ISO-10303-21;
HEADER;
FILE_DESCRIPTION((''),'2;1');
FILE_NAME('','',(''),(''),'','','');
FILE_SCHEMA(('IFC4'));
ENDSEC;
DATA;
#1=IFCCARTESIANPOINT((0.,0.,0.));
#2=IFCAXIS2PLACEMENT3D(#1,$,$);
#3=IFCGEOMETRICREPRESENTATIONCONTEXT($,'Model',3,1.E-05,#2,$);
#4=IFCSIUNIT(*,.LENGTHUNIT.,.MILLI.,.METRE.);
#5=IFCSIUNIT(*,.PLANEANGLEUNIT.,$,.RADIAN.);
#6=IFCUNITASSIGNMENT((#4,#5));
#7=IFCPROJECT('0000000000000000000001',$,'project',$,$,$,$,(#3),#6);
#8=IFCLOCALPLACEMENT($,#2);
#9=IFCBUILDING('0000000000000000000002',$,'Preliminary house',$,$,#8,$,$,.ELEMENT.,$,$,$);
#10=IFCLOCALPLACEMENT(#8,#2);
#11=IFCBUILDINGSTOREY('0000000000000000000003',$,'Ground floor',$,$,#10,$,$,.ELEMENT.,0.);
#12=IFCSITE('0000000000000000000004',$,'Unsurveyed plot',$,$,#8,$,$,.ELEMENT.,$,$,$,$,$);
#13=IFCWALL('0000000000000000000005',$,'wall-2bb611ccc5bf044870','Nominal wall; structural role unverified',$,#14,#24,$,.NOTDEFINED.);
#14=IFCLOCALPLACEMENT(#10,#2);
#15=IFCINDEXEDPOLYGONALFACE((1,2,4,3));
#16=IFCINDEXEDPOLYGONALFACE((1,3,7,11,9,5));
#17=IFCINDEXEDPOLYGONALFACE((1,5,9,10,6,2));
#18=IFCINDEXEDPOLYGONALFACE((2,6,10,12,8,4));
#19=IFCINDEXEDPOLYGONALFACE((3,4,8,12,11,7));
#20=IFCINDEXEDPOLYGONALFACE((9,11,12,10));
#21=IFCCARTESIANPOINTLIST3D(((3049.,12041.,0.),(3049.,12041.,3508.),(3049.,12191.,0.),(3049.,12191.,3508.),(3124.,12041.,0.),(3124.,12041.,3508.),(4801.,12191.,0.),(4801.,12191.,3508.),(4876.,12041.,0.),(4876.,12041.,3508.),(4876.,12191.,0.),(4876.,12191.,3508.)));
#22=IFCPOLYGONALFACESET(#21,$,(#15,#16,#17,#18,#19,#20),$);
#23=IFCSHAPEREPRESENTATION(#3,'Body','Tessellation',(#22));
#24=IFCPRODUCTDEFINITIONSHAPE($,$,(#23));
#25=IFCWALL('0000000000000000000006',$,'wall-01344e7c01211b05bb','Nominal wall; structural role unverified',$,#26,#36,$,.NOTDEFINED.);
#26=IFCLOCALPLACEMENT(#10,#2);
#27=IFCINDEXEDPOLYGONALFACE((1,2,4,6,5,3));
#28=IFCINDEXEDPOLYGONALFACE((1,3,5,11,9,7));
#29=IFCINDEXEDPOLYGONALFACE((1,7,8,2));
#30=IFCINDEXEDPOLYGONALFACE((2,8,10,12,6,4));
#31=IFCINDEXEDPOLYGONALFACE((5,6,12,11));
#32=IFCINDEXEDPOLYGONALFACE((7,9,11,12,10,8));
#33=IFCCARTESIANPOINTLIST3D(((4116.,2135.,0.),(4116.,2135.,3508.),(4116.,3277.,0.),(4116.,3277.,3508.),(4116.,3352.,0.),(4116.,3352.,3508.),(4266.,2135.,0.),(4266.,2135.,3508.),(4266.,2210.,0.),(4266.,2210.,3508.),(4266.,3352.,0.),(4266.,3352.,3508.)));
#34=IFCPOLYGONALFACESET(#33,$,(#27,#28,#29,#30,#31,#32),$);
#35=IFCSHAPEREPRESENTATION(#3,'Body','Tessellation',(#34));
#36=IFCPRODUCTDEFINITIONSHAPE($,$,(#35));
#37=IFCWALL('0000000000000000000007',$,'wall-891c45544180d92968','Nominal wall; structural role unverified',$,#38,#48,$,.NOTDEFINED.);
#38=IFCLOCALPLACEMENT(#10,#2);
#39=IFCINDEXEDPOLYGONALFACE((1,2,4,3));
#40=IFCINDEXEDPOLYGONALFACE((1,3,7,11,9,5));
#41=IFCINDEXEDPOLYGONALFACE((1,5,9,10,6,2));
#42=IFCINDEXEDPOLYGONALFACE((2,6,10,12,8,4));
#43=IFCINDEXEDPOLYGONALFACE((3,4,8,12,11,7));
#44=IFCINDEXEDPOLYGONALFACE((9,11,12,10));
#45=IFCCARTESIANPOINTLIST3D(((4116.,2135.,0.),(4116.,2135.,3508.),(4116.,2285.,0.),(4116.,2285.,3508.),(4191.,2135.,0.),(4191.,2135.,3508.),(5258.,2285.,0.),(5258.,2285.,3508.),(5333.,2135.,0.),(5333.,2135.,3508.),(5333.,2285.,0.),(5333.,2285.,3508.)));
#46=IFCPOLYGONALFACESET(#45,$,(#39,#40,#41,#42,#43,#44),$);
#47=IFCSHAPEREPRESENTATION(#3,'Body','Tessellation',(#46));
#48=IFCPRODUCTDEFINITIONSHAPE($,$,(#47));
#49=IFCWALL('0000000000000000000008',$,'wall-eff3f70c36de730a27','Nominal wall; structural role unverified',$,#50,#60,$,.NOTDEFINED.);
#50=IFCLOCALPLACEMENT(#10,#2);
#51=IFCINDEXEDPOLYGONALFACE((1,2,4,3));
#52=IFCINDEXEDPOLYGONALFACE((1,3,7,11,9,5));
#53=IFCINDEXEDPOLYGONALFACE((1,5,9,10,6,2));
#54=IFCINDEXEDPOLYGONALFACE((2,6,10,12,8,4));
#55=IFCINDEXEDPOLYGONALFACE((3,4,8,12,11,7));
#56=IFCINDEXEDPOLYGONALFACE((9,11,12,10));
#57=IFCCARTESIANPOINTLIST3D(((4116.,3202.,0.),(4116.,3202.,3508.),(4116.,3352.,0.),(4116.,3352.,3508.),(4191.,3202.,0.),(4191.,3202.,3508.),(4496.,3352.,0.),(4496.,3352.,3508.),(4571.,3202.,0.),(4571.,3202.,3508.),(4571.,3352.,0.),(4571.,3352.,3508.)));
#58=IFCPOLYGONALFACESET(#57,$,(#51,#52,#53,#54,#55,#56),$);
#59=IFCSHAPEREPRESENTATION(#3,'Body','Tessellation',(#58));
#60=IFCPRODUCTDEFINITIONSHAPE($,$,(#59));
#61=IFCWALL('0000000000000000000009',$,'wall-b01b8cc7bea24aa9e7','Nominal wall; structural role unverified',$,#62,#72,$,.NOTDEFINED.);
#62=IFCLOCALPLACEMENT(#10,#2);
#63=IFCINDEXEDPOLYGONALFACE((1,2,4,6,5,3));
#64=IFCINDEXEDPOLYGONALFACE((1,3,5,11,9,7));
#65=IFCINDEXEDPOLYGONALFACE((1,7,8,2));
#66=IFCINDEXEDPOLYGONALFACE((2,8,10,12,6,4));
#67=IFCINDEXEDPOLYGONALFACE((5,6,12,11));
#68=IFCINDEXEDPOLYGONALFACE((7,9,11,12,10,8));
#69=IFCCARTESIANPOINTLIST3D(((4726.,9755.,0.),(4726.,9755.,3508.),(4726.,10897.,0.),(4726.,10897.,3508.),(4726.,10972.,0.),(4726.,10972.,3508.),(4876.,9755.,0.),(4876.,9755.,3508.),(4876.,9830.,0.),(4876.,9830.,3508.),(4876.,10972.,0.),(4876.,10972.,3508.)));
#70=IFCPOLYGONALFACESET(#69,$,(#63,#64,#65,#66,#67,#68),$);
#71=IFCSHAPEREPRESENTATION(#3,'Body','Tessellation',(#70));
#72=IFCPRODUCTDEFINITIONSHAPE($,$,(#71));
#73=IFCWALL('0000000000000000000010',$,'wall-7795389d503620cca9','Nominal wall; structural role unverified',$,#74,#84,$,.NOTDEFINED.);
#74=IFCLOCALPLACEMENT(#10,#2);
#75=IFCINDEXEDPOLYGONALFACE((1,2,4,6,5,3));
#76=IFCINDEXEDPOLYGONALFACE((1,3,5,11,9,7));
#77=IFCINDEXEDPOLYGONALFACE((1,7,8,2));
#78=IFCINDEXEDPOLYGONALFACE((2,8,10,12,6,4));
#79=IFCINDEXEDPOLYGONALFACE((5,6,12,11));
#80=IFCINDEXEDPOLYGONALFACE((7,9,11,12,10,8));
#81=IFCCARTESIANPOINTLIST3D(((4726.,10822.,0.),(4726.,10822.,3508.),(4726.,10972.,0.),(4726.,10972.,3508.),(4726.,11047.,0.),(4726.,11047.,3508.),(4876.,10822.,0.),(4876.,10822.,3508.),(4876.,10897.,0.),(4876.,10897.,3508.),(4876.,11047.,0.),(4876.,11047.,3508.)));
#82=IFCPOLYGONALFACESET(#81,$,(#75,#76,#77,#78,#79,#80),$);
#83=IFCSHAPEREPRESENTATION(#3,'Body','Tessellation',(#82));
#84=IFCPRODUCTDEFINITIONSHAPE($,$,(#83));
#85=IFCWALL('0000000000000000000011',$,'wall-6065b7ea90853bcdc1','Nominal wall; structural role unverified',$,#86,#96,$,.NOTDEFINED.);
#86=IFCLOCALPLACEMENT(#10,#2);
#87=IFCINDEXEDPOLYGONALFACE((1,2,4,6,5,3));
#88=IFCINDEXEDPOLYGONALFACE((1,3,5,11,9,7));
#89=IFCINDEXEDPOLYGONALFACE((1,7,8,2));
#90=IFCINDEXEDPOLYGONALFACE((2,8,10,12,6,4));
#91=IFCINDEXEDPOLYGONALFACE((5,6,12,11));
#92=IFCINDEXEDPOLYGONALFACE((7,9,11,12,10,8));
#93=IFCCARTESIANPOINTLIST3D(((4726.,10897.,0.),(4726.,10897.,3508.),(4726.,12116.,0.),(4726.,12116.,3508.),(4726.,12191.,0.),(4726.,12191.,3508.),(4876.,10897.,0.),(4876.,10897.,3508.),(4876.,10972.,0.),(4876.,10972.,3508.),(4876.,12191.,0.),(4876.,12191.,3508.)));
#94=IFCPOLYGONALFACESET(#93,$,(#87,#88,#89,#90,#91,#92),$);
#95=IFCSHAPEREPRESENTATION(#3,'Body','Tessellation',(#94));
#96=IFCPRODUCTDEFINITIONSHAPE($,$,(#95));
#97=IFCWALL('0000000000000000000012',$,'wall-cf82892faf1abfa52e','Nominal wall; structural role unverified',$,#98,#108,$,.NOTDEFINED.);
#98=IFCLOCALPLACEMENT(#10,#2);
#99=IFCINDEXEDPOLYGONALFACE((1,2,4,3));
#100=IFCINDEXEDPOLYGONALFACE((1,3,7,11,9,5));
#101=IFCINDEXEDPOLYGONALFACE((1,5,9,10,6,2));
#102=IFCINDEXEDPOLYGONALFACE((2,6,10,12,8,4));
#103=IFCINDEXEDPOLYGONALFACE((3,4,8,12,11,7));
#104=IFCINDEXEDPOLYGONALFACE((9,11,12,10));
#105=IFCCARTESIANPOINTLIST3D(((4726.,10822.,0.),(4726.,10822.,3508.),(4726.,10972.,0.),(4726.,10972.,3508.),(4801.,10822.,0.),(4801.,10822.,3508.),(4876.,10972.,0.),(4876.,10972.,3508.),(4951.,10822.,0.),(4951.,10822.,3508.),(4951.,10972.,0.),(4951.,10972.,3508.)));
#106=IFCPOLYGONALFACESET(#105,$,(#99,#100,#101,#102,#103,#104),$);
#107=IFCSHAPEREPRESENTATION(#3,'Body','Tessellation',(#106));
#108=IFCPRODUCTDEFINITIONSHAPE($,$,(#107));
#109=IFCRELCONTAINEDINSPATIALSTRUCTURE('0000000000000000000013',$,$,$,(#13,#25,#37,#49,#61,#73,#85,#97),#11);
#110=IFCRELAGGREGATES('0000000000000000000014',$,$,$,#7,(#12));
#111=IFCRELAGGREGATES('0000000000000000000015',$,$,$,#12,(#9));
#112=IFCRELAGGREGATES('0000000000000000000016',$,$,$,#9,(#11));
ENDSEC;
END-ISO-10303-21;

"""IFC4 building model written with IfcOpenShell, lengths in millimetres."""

from ifc_helpers import new_model, si_unit, origin, place, context, project, spatial, polyline, outline, extrude, element, save


model = new_model("IFC4")

# Units and contexts
model_context = context("Model", 3, precision=1e-05, world=origin())
ifc_project = project(units=[si_unit("LENGTHUNIT", "METRE", prefix="MILLI"), si_unit("PLANEANGLEUNIT", "RADIAN")], contexts=[model_context])

# Site, building, storey
placement_1 = place(None, origin())
site = spatial("IfcSite", under=ifc_project, at=placement_1, Name="Unsurveyed plot", CompositionType="ELEMENT")
building = spatial("IfcBuilding", under=site, at=placement_1, Name="Preliminary house", CompositionType="ELEMENT")
placement_2 = place(placement_1, origin())
storey = spatial("IfcBuildingStorey", under=building, at=placement_2, Name="Ground floor", CompositionType="ELEMENT", Elevation=0.0)

# Wall
element("IfcWall", 1, at=placement_2, inside=storey, Name="wall-2bb611ccc5bf044870", Description="Nominal wall; structural role unverified", PredefinedType="NOTDEFINED", context=model_context, shape_type="SweptSolid", body=[
    extrude(outline(polyline([(4801.0, 12191.0), (4876.0, 12191.0), (4876.0, 12041.0), (3124.0, 12041.0), (3049.0, 12041.0), (3049.0, 12191.0), (4801.0, 12191.0)])), origin(), (0.0, 0.0, 1.0), 3508.0),
])

# Walls
element("IfcWall", 2, at=placement_2, inside=storey, Name="wall-01344e7c01211b05bb", Description="Nominal wall; structural role unverified", PredefinedType="NOTDEFINED", context=model_context, shape_type="SweptSolid", body=[
    extrude(outline(polyline([(4116.0, 3277.0), (4116.0, 3352.0), (4266.0, 3352.0), (4266.0, 2210.0), (4266.0, 2135.0), (4116.0, 2135.0), (4116.0, 3277.0)])), origin(), (0.0, 0.0, 1.0), 3508.0),
])
element("IfcWall", 3, at=placement_2, inside=storey, Name="wall-891c45544180d92968", Description="Nominal wall; structural role unverified", PredefinedType="NOTDEFINED", context=model_context, shape_type="SweptSolid", body=[
    extrude(outline(polyline([(5258.0, 2285.0), (5333.0, 2285.0), (5333.0, 2135.0), (4191.0, 2135.0), (4116.0, 2135.0), (4116.0, 2285.0), (5258.0, 2285.0)])), origin(), (0.0, 0.0, 1.0), 3508.0),
])
element("IfcWall", 4, at=placement_2, inside=storey, Name="wall-eff3f70c36de730a27", Description="Nominal wall; structural role unverified", PredefinedType="NOTDEFINED", context=model_context, shape_type="SweptSolid", body=[
    extrude(outline(polyline([(4496.0, 3352.0), (4571.0, 3352.0), (4571.0, 3202.0), (4191.0, 3202.0), (4116.0, 3202.0), (4116.0, 3352.0), (4496.0, 3352.0)])), origin(), (0.0, 0.0, 1.0), 3508.0),
])

# Wall
element("IfcWall", 5, at=placement_2, inside=storey, Name="wall-b01b8cc7bea24aa9e7", Description="Nominal wall; structural role unverified", PredefinedType="NOTDEFINED", context=model_context, shape_type="SweptSolid", body=[
    extrude(outline(polyline([(4726.0, 10897.0), (4726.0, 10972.0), (4876.0, 10972.0), (4876.0, 9830.0), (4876.0, 9755.0), (4726.0, 9755.0), (4726.0, 10897.0)])), origin(), (0.0, 0.0, 1.0), 3508.0),
])

# Walls
element("IfcWall", 6, at=placement_2, inside=storey, Name="wall-7795389d503620cca9", Description="Nominal wall; structural role unverified", PredefinedType="NOTDEFINED", context=model_context, shape_type="SweptSolid", body=[
    extrude(outline(polyline([(4726.0, 10972.0), (4726.0, 11047.0), (4876.0, 11047.0), (4876.0, 10897.0), (4876.0, 10822.0), (4726.0, 10822.0), (4726.0, 10972.0)])), origin(), (0.0, 0.0, 1.0), 3508.0),
])
element("IfcWall", 7, at=placement_2, inside=storey, Name="wall-6065b7ea90853bcdc1", Description="Nominal wall; structural role unverified", PredefinedType="NOTDEFINED", context=model_context, shape_type="SweptSolid", body=[
    extrude(outline(polyline([(4726.0, 12116.0), (4726.0, 12191.0), (4876.0, 12191.0), (4876.0, 10972.0), (4876.0, 10897.0), (4726.0, 10897.0), (4726.0, 12116.0)])), origin(), (0.0, 0.0, 1.0), 3508.0),
])
element("IfcWall", 8, at=placement_2, inside=storey, Name="wall-cf82892faf1abfa52e", Description="Nominal wall; structural role unverified", PredefinedType="NOTDEFINED", context=model_context, shape_type="SweptSolid", body=[
    extrude(outline(polyline([(4876.0, 10972.0), (4951.0, 10972.0), (4951.0, 10822.0), (4801.0, 10822.0), (4726.0, 10822.0), (4726.0, 10972.0), (4876.0, 10972.0)])), origin(), (0.0, 0.0, 1.0), 3508.0),
])

save(model, "model.ifc")
